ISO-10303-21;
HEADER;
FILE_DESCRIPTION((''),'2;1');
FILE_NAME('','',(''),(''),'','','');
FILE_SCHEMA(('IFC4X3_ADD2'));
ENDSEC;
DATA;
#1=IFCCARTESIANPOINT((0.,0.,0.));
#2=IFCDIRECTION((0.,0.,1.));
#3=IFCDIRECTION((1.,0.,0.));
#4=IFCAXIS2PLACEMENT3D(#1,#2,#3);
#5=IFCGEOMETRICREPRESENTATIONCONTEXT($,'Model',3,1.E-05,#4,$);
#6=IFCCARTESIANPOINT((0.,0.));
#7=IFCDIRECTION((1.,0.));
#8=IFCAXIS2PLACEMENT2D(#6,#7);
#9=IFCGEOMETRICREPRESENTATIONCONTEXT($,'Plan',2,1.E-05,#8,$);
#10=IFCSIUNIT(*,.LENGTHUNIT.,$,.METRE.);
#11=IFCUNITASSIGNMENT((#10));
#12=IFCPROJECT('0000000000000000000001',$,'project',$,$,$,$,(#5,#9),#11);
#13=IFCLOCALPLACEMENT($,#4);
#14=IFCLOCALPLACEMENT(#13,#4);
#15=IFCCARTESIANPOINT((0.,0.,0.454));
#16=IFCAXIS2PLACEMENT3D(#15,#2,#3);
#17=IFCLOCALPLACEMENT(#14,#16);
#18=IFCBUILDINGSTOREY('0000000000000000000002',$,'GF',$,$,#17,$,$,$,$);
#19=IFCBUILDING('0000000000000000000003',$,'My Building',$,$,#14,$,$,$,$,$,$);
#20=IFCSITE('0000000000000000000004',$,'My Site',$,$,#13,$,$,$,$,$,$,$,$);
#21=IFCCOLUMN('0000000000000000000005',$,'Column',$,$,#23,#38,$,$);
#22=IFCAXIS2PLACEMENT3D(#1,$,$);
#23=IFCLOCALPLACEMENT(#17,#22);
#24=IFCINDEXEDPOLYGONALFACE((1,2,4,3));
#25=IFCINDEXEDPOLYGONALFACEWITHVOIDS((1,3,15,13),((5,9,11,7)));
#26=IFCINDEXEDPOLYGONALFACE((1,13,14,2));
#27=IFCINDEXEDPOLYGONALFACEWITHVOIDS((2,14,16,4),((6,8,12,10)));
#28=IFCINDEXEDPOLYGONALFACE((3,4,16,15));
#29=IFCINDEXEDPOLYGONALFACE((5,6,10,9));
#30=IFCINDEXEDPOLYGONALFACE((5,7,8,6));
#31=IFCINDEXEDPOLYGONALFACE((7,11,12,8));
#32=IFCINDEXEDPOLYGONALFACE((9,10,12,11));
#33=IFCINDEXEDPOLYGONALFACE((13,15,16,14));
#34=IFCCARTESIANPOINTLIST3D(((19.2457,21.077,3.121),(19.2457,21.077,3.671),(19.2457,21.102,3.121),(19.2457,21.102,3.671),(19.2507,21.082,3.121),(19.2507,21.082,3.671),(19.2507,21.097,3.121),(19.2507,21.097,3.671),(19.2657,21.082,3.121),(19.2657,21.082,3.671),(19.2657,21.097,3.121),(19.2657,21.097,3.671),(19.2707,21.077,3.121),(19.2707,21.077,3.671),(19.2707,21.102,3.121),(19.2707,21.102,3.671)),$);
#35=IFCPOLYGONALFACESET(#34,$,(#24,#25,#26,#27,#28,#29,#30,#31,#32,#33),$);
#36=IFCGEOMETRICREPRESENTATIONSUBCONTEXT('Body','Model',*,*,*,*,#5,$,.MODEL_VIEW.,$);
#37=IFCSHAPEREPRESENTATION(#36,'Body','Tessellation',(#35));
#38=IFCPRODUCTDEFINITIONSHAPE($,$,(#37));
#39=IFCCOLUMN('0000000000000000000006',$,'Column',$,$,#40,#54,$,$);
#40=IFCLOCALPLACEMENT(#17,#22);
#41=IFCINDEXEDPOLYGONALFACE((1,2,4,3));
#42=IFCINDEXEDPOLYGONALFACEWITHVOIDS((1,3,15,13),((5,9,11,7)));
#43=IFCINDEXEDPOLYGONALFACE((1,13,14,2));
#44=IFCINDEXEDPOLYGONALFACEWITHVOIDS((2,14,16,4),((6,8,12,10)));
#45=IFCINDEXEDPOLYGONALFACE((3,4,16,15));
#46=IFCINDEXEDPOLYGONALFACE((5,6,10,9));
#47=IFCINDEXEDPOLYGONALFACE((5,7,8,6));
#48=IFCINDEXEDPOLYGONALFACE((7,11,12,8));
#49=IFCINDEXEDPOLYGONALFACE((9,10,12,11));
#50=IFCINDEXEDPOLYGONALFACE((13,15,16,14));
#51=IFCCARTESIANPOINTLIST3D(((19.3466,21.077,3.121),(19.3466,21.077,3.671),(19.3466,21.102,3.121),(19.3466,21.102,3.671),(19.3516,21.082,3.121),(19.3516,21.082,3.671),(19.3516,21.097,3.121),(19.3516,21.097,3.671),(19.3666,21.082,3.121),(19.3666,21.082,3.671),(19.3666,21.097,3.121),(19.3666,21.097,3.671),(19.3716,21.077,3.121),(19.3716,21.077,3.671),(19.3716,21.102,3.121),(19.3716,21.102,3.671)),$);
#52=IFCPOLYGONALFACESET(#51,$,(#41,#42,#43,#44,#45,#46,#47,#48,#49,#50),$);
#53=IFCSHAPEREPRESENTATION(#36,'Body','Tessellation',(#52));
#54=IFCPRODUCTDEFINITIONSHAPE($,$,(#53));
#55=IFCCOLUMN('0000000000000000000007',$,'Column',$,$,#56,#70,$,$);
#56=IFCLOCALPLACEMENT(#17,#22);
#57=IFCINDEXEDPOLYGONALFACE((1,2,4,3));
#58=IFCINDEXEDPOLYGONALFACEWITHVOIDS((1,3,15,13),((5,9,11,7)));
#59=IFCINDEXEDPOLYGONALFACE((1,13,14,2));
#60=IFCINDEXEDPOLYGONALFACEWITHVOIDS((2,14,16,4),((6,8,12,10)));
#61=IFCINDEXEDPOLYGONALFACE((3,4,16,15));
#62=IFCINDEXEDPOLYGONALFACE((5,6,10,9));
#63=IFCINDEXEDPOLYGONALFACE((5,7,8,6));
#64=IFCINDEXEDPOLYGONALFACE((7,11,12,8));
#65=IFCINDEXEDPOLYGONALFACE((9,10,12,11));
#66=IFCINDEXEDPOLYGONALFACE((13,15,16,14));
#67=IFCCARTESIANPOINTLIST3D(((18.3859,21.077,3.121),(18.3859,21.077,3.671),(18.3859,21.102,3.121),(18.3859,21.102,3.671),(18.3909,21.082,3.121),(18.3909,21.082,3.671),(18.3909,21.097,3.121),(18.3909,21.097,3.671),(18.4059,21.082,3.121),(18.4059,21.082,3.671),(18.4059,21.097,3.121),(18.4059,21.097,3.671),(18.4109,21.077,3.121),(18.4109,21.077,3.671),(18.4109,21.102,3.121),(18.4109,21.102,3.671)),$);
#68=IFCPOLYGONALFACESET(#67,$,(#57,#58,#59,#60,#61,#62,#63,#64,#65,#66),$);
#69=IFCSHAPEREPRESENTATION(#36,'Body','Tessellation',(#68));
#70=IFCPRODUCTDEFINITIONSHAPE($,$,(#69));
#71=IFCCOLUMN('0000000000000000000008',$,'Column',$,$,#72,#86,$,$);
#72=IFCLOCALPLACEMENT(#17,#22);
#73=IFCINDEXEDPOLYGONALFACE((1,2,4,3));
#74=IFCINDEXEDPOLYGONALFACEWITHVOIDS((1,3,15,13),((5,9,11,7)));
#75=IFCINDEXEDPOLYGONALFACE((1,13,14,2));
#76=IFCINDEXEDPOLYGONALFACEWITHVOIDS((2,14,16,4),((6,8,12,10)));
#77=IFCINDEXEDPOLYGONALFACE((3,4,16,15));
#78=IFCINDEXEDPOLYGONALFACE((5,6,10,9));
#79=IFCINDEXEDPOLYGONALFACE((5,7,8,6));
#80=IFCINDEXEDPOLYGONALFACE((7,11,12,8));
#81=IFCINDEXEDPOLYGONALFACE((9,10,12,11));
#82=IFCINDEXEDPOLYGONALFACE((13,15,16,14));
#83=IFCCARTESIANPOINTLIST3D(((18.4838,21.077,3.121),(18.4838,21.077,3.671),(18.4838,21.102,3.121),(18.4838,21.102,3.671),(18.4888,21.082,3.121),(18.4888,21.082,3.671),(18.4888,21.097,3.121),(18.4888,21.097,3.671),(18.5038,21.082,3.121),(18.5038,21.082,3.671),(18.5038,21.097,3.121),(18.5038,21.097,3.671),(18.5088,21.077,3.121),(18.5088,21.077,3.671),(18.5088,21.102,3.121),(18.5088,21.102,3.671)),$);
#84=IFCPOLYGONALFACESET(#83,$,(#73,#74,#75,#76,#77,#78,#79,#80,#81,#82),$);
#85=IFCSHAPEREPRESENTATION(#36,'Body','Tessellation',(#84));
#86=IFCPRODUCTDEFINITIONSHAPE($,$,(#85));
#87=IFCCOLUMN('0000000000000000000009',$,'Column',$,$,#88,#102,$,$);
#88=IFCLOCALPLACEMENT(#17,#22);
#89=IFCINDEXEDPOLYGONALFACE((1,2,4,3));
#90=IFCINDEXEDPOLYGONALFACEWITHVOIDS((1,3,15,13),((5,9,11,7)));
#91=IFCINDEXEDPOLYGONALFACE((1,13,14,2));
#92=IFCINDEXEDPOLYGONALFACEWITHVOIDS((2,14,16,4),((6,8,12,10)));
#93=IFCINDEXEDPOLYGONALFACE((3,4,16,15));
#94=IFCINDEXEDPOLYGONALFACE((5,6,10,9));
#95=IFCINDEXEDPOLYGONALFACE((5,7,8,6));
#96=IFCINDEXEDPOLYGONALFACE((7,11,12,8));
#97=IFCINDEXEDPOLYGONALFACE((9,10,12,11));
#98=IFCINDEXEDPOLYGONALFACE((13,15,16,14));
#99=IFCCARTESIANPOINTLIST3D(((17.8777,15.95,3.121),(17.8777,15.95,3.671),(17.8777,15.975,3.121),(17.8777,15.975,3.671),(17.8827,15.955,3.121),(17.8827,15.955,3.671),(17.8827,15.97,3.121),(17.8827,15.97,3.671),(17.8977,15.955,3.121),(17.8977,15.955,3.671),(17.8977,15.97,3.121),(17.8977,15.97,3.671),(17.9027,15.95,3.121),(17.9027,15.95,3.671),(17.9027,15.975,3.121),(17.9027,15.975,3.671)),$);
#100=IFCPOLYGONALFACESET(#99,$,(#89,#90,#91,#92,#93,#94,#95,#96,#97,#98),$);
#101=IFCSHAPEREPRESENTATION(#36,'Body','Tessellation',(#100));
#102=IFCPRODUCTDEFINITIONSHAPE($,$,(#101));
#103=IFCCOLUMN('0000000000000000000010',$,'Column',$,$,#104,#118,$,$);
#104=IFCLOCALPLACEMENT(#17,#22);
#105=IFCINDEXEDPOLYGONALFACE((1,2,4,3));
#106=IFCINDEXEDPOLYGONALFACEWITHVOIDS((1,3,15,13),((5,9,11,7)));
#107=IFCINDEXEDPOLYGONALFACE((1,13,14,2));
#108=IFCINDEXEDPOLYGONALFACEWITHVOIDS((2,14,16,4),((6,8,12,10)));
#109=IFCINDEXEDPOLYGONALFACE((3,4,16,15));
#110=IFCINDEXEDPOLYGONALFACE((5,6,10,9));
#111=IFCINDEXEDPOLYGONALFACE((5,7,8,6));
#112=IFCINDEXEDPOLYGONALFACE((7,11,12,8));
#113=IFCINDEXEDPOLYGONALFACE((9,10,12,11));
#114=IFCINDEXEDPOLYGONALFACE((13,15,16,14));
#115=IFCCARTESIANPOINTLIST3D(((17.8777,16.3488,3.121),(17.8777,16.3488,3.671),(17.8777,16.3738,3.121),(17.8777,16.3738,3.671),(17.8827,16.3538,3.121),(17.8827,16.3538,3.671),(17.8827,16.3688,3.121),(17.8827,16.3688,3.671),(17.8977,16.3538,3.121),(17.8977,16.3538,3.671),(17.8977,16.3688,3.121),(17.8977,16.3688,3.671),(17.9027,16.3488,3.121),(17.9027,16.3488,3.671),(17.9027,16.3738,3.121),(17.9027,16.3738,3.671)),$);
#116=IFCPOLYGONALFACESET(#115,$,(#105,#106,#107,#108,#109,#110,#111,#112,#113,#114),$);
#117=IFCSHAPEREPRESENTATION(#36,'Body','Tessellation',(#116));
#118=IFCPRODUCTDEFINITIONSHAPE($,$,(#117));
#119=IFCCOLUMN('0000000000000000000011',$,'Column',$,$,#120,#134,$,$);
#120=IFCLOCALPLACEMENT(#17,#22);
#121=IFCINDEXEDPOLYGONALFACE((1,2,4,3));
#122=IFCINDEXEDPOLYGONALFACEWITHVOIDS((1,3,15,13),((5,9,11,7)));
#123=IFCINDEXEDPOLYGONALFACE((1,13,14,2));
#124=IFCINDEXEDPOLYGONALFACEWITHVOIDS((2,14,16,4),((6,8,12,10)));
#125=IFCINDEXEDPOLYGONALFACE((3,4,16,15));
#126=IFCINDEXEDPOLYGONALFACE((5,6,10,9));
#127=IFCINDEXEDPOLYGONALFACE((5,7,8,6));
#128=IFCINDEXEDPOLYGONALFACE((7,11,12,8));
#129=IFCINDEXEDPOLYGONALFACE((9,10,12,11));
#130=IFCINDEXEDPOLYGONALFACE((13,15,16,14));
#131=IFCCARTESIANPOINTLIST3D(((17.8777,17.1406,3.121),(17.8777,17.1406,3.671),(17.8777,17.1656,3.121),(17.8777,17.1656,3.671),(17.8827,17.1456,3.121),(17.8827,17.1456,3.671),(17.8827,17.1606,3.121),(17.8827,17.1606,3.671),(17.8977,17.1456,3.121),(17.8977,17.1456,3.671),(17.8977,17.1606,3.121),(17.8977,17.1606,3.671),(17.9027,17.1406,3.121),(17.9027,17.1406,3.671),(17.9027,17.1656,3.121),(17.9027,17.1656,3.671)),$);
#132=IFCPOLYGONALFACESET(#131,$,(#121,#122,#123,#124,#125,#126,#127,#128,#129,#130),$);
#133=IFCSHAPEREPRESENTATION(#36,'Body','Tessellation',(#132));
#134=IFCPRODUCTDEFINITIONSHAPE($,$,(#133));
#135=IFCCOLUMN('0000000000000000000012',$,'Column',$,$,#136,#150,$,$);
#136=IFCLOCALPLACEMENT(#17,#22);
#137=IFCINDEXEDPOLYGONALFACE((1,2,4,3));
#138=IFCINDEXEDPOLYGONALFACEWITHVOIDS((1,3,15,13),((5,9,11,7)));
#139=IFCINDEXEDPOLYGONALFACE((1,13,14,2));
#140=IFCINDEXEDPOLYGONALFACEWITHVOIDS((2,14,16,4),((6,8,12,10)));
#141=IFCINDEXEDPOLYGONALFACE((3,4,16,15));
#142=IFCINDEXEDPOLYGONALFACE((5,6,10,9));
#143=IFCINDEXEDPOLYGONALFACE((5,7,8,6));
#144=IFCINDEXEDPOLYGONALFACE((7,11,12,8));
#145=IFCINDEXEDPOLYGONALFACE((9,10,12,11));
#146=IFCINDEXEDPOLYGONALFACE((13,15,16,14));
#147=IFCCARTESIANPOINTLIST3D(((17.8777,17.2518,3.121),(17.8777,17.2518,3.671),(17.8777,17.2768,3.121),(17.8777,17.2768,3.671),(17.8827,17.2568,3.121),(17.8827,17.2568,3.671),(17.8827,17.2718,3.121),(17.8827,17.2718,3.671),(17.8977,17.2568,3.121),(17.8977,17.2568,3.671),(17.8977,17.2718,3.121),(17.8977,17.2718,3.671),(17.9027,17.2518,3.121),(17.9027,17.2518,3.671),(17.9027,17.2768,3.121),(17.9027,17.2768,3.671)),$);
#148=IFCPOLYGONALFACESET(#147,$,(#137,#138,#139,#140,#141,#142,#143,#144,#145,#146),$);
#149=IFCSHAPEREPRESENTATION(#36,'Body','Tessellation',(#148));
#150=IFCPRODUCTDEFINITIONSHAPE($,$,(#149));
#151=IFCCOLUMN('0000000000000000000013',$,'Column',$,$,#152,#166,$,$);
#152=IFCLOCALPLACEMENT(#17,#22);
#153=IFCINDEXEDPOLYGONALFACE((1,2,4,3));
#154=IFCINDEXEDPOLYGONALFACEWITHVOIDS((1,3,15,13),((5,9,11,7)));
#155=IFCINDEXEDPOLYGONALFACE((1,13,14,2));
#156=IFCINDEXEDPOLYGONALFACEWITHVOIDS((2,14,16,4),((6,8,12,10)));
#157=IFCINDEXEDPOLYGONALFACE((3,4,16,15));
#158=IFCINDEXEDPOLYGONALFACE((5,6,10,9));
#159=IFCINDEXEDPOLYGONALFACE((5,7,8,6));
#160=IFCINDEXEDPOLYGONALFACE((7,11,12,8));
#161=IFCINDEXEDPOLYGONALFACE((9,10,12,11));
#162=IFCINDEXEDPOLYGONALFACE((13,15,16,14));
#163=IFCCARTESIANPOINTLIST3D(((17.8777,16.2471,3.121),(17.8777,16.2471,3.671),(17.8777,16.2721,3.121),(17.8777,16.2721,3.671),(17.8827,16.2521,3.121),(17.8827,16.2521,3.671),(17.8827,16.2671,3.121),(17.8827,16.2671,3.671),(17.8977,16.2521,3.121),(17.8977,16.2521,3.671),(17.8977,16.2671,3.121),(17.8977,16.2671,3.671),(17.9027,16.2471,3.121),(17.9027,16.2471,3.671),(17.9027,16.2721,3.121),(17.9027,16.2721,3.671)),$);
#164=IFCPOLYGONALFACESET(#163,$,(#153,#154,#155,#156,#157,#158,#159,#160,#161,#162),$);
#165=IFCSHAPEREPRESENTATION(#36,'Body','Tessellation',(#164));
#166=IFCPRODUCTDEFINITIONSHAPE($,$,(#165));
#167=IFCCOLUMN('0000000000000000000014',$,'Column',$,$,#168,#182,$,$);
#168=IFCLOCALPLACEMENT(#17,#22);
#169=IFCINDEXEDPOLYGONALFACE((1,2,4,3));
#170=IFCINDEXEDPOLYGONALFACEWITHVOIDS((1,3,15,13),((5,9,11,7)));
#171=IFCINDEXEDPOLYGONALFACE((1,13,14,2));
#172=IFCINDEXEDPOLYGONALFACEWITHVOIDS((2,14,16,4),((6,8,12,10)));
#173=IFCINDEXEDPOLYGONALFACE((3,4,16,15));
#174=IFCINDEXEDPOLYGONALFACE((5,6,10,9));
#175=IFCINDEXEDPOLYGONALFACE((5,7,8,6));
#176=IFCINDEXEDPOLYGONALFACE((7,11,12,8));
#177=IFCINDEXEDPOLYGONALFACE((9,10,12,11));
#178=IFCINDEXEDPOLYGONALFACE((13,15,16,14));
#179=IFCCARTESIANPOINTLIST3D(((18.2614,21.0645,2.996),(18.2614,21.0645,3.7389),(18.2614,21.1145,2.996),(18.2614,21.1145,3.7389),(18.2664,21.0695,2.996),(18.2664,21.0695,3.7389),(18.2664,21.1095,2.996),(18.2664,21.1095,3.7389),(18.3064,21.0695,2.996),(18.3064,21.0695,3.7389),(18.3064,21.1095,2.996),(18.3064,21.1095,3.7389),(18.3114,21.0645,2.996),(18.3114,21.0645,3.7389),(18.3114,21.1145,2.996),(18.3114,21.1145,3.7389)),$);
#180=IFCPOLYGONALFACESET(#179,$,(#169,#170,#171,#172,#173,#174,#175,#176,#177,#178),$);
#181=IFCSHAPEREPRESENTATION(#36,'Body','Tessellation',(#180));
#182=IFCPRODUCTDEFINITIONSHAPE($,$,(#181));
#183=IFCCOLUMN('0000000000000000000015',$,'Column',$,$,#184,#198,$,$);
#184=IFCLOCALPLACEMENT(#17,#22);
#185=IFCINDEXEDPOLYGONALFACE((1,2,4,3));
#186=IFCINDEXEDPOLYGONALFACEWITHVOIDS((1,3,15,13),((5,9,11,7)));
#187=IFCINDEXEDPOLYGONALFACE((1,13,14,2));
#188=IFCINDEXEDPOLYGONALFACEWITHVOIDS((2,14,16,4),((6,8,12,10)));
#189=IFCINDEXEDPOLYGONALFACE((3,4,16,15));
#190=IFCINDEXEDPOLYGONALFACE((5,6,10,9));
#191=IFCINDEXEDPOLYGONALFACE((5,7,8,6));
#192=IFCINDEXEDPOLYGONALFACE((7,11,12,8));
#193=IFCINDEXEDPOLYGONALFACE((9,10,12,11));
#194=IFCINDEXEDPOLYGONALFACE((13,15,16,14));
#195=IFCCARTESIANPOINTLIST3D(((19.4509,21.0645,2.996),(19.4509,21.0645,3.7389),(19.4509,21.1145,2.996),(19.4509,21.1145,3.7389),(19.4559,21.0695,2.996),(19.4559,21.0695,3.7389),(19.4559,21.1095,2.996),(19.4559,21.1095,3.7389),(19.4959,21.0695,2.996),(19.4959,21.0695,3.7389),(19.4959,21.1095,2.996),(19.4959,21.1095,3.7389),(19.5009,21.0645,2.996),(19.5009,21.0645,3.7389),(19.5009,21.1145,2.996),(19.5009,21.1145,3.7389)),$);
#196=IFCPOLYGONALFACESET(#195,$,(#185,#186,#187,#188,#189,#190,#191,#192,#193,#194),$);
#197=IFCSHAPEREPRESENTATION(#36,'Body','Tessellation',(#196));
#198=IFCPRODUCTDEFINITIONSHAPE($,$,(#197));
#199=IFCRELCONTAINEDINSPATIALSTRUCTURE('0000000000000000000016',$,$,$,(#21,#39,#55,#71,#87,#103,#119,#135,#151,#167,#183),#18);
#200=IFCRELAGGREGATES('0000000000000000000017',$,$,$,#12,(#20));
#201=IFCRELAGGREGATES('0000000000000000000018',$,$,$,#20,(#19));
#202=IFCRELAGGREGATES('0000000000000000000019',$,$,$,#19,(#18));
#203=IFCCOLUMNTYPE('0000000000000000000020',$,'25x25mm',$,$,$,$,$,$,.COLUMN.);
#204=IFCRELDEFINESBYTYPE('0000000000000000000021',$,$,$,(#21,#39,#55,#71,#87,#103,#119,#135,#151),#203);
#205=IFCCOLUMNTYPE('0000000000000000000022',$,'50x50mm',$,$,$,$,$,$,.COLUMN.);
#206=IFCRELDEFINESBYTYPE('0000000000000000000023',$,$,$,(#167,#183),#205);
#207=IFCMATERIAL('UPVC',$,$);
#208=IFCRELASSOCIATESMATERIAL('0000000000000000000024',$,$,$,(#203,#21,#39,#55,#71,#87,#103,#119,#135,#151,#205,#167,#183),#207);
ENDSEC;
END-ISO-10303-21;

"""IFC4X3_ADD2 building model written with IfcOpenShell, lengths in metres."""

from ifc_helpers import new_model, si_unit, frame, origin_with_axes, origin_2d_with_axis, place, context, subcontext, project, spatial, hollow_rectangle, extrude, material, material_profile, profile_set, profile_usage, type_object, element, save


model = new_model("IFC4X3_ADD2")

# Units and contexts
model_context = context("Model", 3, precision=1e-05, world=origin_with_axes())
plan_context = context("Plan", 2, precision=1e-05, world=origin_2d_with_axis())
body_context_1 = subcontext(model_context, "Body", "Model", "MODEL_VIEW")
ifc_project = project(units=[si_unit("LENGTHUNIT", "METRE")], contexts=[model_context, plan_context])

# Site, building, storey
site_placement = place(None, origin_with_axes())
site = spatial("IfcSite", under=ifc_project, at=site_placement, Name="My Site")
building_placement = place(site_placement, origin_with_axes())
building = spatial("IfcBuilding", under=site, at=building_placement, Name="My Building")
storey_placement = place(building_placement, frame((0.0, 0.0, 0.454), z_axis=(0.0, 0.0, 1.0), x_axis=(1.0, 0.0, 0.0)))
storey = spatial("IfcBuildingStorey", under=building, at=storey_placement, Name="GF")

# Columns
ifc_material_1 = material(Name="UPVC")
ifc_material_profile_1 = material_profile(ifc_material_1, hollow_rectangle(XDim=0.025, YDim=0.025, WallThickness=0.005))
ifc_profile_set_1 = profile_set([ifc_material_profile_1])
ifc_profile_usage_1 = profile_usage(ifc_profile_set_1)
column_type_1 = type_object("IfcColumnType", Name="25x25mm", PredefinedType="COLUMN", material=ifc_profile_set_1)
column_1_placement = place(storey_placement, frame((19.2582, 21.0895, 3.121), z_axis=(0.0, 0.0, 1.0), x_axis=(0.0, -1.0, 0.0)))
element("IfcColumn", 1, at=column_1_placement, inside=storey, type_object=column_type_1, material=ifc_profile_usage_1, Name="Column", context=body_context_1, shape_type="SweptSolid", body=[
    extrude(hollow_rectangle(XDim=0.025, YDim=0.025, WallThickness=0.005), origin_with_axes(), (0.0, 0.0, 1.0), 0.55),
])
ifc_profile_usage_2 = profile_usage(ifc_profile_set_1)
column_2_placement = place(storey_placement, frame((19.3591, 21.0895, 3.121), z_axis=(0.0, 0.0, 1.0), x_axis=(0.0, -1.0, 0.0)))
element("IfcColumn", 2, at=column_2_placement, inside=storey, type_object=column_type_1, material=ifc_profile_usage_2, Name="Column", context=body_context_1, shape_type="SweptSolid", body=[
    extrude(hollow_rectangle(XDim=0.025, YDim=0.025, WallThickness=0.005), origin_with_axes(), (0.0, 0.0, 1.0), 0.55),
])
ifc_profile_usage_3 = profile_usage(ifc_profile_set_1)
column_3_placement = place(storey_placement, frame((18.3984, 21.0895, 3.121), z_axis=(0.0, 0.0, 1.0), x_axis=(0.0, -1.0, 0.0)))
element("IfcColumn", 3, at=column_3_placement, inside=storey, type_object=column_type_1, material=ifc_profile_usage_3, Name="Column", context=body_context_1, shape_type="SweptSolid", body=[
    extrude(hollow_rectangle(XDim=0.025, YDim=0.025, WallThickness=0.005), origin_with_axes(), (0.0, 0.0, 1.0), 0.55),
])
ifc_profile_usage_4 = profile_usage(ifc_profile_set_1)
column_4_placement = place(storey_placement, frame((18.4963, 21.0895, 3.121), z_axis=(0.0, 0.0, 1.0), x_axis=(0.0, -1.0, 0.0)))
element("IfcColumn", 4, at=column_4_placement, inside=storey, type_object=column_type_1, material=ifc_profile_usage_4, Name="Column", context=body_context_1, shape_type="SweptSolid", body=[
    extrude(hollow_rectangle(XDim=0.025, YDim=0.025, WallThickness=0.005), origin_with_axes(), (0.0, 0.0, 1.0), 0.55),
])
ifc_profile_usage_5 = profile_usage(ifc_profile_set_1)
column_5_placement = place(storey_placement, frame((17.8902, 15.9625, 3.121), z_axis=(0.0, 0.0, 1.0), x_axis=(0.0, -1.0, 0.0)))
element("IfcColumn", 5, at=column_5_placement, inside=storey, type_object=column_type_1, material=ifc_profile_usage_5, Name="Column", context=body_context_1, shape_type="SweptSolid", body=[
    extrude(hollow_rectangle(XDim=0.025, YDim=0.025, WallThickness=0.005), origin_with_axes(), (0.0, 0.0, 1.0), 0.55),
])
ifc_profile_usage_6 = profile_usage(ifc_profile_set_1)
column_6_placement = place(storey_placement, frame((17.8902, 16.3613, 3.121), z_axis=(0.0, 0.0, 1.0), x_axis=(0.0, -1.0, 0.0)))
element("IfcColumn", 6, at=column_6_placement, inside=storey, type_object=column_type_1, material=ifc_profile_usage_6, Name="Column", context=body_context_1, shape_type="SweptSolid", body=[
    extrude(hollow_rectangle(XDim=0.025, YDim=0.025, WallThickness=0.005), origin_with_axes(), (0.0, 0.0, 1.0), 0.55),
])
ifc_profile_usage_7 = profile_usage(ifc_profile_set_1)
column_7_placement = place(storey_placement, frame((17.8902, 17.1531, 3.121), z_axis=(0.0, 0.0, 1.0), x_axis=(0.0, -1.0, 0.0)))
element("IfcColumn", 7, at=column_7_placement, inside=storey, type_object=column_type_1, material=ifc_profile_usage_7, Name="Column", context=body_context_1, shape_type="SweptSolid", body=[
    extrude(hollow_rectangle(XDim=0.025, YDim=0.025, WallThickness=0.005), origin_with_axes(), (0.0, 0.0, 1.0), 0.55),
])
ifc_profile_usage_8 = profile_usage(ifc_profile_set_1)
column_8_placement = place(storey_placement, frame((17.8902, 17.2643, 3.121), z_axis=(0.0, 0.0, 1.0), x_axis=(0.0, -1.0, 0.0)))
element("IfcColumn", 8, at=column_8_placement, inside=storey, type_object=column_type_1, material=ifc_profile_usage_8, Name="Column", context=body_context_1, shape_type="SweptSolid", body=[
    extrude(hollow_rectangle(XDim=0.025, YDim=0.025, WallThickness=0.005), origin_with_axes(), (0.0, 0.0, 1.0), 0.55),
])
ifc_profile_usage_9 = profile_usage(ifc_profile_set_1)
column_9_placement = place(storey_placement, frame((17.8902, 16.2596, 3.121), z_axis=(0.0, 0.0, 1.0), x_axis=(0.0, -1.0, 0.0)))
element("IfcColumn", 9, at=column_9_placement, inside=storey, type_object=column_type_1, material=ifc_profile_usage_9, Name="Column", context=body_context_1, shape_type="SweptSolid", body=[
    extrude(hollow_rectangle(XDim=0.025, YDim=0.025, WallThickness=0.005), origin_with_axes(), (0.0, 0.0, 1.0), 0.55),
])
ifc_material_profile_2 = material_profile(ifc_material_1, hollow_rectangle(XDim=0.05, YDim=0.05, WallThickness=0.005))
ifc_profile_set_2 = profile_set([ifc_material_profile_2])
ifc_profile_usage_10 = profile_usage(ifc_profile_set_2)
column_type_2 = type_object("IfcColumnType", Name="50x50mm", PredefinedType="COLUMN", material=ifc_profile_set_2)
column_10_placement = place(storey_placement, frame((18.2864, 21.0895, 2.996), z_axis=(0.0, 0.0, 1.0), x_axis=(1.0, 0.0, 0.0)))
element("IfcColumn", 10, at=column_10_placement, inside=storey, type_object=column_type_2, material=ifc_profile_usage_10, Name="Column", context=body_context_1, shape_type="SweptSolid", body=[
    extrude(hollow_rectangle(XDim=0.05, YDim=0.05, WallThickness=0.005), origin_with_axes(), (0.0, 0.0, 1.0), 0.7429),
])
ifc_profile_usage_11 = profile_usage(ifc_profile_set_2)
column_11_placement = place(storey_placement, frame((19.4759, 21.0895, 2.996), z_axis=(0.0, 0.0, 1.0), x_axis=(1.0, 0.0, 0.0)))
element("IfcColumn", 11, at=column_11_placement, inside=storey, type_object=column_type_2, material=ifc_profile_usage_11, Name="Column", context=body_context_1, shape_type="SweptSolid", body=[
    extrude(hollow_rectangle(XDim=0.05, YDim=0.05, WallThickness=0.005), origin_with_axes(), (0.0, 0.0, 1.0), 0.7429),
])

save(model, "model.ifc")
